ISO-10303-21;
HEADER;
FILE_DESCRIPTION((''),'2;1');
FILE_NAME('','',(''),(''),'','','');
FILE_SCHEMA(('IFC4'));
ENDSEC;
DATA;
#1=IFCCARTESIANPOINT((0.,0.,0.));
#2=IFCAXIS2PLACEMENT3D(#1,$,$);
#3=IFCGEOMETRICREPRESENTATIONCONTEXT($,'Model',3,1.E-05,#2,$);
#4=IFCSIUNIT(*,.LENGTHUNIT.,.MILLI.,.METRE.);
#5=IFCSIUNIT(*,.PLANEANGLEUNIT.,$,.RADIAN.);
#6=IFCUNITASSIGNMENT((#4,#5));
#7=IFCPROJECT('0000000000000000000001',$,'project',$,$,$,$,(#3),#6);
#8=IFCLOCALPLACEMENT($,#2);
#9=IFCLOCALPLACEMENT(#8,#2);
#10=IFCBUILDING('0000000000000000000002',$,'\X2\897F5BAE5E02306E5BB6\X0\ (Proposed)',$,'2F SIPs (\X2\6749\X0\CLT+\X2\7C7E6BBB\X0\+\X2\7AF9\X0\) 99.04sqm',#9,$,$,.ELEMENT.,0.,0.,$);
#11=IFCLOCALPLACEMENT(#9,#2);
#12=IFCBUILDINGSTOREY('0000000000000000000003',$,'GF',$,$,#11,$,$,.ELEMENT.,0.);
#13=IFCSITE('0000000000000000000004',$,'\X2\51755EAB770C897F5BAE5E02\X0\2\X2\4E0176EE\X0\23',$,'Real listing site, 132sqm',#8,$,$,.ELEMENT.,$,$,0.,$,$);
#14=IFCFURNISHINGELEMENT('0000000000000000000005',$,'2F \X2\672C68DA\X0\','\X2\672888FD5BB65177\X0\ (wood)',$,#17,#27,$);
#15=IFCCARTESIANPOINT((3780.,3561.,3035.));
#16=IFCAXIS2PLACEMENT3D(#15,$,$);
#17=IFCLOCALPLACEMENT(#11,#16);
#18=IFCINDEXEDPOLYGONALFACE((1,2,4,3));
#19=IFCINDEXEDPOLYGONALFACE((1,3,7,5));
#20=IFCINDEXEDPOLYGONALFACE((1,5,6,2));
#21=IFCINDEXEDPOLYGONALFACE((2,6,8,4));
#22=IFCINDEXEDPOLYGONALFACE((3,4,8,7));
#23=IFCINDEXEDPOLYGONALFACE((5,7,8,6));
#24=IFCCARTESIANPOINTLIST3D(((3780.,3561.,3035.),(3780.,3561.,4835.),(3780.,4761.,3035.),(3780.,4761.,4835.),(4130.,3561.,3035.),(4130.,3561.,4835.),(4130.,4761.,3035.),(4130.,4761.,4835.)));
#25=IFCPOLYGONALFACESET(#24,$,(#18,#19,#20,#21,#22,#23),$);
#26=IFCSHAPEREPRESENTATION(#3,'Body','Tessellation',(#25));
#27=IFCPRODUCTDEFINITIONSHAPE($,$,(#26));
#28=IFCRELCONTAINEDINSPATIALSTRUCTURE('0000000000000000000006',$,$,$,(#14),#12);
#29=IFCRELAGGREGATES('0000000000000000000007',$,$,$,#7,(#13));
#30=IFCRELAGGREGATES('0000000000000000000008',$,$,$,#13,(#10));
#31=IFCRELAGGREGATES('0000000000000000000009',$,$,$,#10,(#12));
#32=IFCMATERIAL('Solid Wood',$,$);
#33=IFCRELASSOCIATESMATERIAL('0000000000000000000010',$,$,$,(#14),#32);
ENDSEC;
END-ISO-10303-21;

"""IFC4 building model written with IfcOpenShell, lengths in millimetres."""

from ifc_helpers import new_model, si_unit, frame, frame_2d, origin, place, context, project, spatial, rectangle, extrude, material, element, save


model = new_model("IFC4")

# Units and contexts
model_context = context("Model", 3, precision=1e-05, world=origin())
ifc_project = project(units=[si_unit("LENGTHUNIT", "METRE", prefix="MILLI"), si_unit("PLANEANGLEUNIT", "RADIAN")], contexts=[model_context])

# Site, building, storey
site_placement = place(None, origin())
site = spatial("IfcSite", under=ifc_project, at=site_placement, Name="兵庫県西宮市2丁目23", ObjectType="Real listing site, 132sqm", CompositionType="ELEMENT", RefElevation=0.0)
building_placement = place(site_placement, origin())
building = spatial("IfcBuilding", under=site, at=building_placement, Name="西宮市の家 (Proposed)", ObjectType="2F SIPs (杉CLT+籾殻+竹) 99.04sqm", CompositionType="ELEMENT", ElevationOfRefHeight=0.0, ElevationOfTerrain=0.0)
storey_placement = place(building_placement, origin())
storey = spatial("IfcBuildingStorey", under=building, at=storey_placement, Name="GF", CompositionType="ELEMENT", Elevation=0.0)

# Shared definitions
ifc_material_1 = material(Name="Solid Wood")

# Furnishing element
furnishing_placement = place(storey_placement, frame((3780.0, 3561.0, 3035.0)))
element("IfcFurnishingElement", 1, at=furnishing_placement, inside=storey, material=ifc_material_1, Name="2F 本棚", Description="木製家具 (wood)", context=model_context, shape_type="SweptSolid", body=[
    extrude(rectangle(XDim=350.0, YDim=1200.0, at=frame_2d((175.0, 600.0))), frame((3780.0, 3561.0, 3035.0)), (0.0, 0.0, 1.0), 1800.0),
])

save(model, "model.ifc")
